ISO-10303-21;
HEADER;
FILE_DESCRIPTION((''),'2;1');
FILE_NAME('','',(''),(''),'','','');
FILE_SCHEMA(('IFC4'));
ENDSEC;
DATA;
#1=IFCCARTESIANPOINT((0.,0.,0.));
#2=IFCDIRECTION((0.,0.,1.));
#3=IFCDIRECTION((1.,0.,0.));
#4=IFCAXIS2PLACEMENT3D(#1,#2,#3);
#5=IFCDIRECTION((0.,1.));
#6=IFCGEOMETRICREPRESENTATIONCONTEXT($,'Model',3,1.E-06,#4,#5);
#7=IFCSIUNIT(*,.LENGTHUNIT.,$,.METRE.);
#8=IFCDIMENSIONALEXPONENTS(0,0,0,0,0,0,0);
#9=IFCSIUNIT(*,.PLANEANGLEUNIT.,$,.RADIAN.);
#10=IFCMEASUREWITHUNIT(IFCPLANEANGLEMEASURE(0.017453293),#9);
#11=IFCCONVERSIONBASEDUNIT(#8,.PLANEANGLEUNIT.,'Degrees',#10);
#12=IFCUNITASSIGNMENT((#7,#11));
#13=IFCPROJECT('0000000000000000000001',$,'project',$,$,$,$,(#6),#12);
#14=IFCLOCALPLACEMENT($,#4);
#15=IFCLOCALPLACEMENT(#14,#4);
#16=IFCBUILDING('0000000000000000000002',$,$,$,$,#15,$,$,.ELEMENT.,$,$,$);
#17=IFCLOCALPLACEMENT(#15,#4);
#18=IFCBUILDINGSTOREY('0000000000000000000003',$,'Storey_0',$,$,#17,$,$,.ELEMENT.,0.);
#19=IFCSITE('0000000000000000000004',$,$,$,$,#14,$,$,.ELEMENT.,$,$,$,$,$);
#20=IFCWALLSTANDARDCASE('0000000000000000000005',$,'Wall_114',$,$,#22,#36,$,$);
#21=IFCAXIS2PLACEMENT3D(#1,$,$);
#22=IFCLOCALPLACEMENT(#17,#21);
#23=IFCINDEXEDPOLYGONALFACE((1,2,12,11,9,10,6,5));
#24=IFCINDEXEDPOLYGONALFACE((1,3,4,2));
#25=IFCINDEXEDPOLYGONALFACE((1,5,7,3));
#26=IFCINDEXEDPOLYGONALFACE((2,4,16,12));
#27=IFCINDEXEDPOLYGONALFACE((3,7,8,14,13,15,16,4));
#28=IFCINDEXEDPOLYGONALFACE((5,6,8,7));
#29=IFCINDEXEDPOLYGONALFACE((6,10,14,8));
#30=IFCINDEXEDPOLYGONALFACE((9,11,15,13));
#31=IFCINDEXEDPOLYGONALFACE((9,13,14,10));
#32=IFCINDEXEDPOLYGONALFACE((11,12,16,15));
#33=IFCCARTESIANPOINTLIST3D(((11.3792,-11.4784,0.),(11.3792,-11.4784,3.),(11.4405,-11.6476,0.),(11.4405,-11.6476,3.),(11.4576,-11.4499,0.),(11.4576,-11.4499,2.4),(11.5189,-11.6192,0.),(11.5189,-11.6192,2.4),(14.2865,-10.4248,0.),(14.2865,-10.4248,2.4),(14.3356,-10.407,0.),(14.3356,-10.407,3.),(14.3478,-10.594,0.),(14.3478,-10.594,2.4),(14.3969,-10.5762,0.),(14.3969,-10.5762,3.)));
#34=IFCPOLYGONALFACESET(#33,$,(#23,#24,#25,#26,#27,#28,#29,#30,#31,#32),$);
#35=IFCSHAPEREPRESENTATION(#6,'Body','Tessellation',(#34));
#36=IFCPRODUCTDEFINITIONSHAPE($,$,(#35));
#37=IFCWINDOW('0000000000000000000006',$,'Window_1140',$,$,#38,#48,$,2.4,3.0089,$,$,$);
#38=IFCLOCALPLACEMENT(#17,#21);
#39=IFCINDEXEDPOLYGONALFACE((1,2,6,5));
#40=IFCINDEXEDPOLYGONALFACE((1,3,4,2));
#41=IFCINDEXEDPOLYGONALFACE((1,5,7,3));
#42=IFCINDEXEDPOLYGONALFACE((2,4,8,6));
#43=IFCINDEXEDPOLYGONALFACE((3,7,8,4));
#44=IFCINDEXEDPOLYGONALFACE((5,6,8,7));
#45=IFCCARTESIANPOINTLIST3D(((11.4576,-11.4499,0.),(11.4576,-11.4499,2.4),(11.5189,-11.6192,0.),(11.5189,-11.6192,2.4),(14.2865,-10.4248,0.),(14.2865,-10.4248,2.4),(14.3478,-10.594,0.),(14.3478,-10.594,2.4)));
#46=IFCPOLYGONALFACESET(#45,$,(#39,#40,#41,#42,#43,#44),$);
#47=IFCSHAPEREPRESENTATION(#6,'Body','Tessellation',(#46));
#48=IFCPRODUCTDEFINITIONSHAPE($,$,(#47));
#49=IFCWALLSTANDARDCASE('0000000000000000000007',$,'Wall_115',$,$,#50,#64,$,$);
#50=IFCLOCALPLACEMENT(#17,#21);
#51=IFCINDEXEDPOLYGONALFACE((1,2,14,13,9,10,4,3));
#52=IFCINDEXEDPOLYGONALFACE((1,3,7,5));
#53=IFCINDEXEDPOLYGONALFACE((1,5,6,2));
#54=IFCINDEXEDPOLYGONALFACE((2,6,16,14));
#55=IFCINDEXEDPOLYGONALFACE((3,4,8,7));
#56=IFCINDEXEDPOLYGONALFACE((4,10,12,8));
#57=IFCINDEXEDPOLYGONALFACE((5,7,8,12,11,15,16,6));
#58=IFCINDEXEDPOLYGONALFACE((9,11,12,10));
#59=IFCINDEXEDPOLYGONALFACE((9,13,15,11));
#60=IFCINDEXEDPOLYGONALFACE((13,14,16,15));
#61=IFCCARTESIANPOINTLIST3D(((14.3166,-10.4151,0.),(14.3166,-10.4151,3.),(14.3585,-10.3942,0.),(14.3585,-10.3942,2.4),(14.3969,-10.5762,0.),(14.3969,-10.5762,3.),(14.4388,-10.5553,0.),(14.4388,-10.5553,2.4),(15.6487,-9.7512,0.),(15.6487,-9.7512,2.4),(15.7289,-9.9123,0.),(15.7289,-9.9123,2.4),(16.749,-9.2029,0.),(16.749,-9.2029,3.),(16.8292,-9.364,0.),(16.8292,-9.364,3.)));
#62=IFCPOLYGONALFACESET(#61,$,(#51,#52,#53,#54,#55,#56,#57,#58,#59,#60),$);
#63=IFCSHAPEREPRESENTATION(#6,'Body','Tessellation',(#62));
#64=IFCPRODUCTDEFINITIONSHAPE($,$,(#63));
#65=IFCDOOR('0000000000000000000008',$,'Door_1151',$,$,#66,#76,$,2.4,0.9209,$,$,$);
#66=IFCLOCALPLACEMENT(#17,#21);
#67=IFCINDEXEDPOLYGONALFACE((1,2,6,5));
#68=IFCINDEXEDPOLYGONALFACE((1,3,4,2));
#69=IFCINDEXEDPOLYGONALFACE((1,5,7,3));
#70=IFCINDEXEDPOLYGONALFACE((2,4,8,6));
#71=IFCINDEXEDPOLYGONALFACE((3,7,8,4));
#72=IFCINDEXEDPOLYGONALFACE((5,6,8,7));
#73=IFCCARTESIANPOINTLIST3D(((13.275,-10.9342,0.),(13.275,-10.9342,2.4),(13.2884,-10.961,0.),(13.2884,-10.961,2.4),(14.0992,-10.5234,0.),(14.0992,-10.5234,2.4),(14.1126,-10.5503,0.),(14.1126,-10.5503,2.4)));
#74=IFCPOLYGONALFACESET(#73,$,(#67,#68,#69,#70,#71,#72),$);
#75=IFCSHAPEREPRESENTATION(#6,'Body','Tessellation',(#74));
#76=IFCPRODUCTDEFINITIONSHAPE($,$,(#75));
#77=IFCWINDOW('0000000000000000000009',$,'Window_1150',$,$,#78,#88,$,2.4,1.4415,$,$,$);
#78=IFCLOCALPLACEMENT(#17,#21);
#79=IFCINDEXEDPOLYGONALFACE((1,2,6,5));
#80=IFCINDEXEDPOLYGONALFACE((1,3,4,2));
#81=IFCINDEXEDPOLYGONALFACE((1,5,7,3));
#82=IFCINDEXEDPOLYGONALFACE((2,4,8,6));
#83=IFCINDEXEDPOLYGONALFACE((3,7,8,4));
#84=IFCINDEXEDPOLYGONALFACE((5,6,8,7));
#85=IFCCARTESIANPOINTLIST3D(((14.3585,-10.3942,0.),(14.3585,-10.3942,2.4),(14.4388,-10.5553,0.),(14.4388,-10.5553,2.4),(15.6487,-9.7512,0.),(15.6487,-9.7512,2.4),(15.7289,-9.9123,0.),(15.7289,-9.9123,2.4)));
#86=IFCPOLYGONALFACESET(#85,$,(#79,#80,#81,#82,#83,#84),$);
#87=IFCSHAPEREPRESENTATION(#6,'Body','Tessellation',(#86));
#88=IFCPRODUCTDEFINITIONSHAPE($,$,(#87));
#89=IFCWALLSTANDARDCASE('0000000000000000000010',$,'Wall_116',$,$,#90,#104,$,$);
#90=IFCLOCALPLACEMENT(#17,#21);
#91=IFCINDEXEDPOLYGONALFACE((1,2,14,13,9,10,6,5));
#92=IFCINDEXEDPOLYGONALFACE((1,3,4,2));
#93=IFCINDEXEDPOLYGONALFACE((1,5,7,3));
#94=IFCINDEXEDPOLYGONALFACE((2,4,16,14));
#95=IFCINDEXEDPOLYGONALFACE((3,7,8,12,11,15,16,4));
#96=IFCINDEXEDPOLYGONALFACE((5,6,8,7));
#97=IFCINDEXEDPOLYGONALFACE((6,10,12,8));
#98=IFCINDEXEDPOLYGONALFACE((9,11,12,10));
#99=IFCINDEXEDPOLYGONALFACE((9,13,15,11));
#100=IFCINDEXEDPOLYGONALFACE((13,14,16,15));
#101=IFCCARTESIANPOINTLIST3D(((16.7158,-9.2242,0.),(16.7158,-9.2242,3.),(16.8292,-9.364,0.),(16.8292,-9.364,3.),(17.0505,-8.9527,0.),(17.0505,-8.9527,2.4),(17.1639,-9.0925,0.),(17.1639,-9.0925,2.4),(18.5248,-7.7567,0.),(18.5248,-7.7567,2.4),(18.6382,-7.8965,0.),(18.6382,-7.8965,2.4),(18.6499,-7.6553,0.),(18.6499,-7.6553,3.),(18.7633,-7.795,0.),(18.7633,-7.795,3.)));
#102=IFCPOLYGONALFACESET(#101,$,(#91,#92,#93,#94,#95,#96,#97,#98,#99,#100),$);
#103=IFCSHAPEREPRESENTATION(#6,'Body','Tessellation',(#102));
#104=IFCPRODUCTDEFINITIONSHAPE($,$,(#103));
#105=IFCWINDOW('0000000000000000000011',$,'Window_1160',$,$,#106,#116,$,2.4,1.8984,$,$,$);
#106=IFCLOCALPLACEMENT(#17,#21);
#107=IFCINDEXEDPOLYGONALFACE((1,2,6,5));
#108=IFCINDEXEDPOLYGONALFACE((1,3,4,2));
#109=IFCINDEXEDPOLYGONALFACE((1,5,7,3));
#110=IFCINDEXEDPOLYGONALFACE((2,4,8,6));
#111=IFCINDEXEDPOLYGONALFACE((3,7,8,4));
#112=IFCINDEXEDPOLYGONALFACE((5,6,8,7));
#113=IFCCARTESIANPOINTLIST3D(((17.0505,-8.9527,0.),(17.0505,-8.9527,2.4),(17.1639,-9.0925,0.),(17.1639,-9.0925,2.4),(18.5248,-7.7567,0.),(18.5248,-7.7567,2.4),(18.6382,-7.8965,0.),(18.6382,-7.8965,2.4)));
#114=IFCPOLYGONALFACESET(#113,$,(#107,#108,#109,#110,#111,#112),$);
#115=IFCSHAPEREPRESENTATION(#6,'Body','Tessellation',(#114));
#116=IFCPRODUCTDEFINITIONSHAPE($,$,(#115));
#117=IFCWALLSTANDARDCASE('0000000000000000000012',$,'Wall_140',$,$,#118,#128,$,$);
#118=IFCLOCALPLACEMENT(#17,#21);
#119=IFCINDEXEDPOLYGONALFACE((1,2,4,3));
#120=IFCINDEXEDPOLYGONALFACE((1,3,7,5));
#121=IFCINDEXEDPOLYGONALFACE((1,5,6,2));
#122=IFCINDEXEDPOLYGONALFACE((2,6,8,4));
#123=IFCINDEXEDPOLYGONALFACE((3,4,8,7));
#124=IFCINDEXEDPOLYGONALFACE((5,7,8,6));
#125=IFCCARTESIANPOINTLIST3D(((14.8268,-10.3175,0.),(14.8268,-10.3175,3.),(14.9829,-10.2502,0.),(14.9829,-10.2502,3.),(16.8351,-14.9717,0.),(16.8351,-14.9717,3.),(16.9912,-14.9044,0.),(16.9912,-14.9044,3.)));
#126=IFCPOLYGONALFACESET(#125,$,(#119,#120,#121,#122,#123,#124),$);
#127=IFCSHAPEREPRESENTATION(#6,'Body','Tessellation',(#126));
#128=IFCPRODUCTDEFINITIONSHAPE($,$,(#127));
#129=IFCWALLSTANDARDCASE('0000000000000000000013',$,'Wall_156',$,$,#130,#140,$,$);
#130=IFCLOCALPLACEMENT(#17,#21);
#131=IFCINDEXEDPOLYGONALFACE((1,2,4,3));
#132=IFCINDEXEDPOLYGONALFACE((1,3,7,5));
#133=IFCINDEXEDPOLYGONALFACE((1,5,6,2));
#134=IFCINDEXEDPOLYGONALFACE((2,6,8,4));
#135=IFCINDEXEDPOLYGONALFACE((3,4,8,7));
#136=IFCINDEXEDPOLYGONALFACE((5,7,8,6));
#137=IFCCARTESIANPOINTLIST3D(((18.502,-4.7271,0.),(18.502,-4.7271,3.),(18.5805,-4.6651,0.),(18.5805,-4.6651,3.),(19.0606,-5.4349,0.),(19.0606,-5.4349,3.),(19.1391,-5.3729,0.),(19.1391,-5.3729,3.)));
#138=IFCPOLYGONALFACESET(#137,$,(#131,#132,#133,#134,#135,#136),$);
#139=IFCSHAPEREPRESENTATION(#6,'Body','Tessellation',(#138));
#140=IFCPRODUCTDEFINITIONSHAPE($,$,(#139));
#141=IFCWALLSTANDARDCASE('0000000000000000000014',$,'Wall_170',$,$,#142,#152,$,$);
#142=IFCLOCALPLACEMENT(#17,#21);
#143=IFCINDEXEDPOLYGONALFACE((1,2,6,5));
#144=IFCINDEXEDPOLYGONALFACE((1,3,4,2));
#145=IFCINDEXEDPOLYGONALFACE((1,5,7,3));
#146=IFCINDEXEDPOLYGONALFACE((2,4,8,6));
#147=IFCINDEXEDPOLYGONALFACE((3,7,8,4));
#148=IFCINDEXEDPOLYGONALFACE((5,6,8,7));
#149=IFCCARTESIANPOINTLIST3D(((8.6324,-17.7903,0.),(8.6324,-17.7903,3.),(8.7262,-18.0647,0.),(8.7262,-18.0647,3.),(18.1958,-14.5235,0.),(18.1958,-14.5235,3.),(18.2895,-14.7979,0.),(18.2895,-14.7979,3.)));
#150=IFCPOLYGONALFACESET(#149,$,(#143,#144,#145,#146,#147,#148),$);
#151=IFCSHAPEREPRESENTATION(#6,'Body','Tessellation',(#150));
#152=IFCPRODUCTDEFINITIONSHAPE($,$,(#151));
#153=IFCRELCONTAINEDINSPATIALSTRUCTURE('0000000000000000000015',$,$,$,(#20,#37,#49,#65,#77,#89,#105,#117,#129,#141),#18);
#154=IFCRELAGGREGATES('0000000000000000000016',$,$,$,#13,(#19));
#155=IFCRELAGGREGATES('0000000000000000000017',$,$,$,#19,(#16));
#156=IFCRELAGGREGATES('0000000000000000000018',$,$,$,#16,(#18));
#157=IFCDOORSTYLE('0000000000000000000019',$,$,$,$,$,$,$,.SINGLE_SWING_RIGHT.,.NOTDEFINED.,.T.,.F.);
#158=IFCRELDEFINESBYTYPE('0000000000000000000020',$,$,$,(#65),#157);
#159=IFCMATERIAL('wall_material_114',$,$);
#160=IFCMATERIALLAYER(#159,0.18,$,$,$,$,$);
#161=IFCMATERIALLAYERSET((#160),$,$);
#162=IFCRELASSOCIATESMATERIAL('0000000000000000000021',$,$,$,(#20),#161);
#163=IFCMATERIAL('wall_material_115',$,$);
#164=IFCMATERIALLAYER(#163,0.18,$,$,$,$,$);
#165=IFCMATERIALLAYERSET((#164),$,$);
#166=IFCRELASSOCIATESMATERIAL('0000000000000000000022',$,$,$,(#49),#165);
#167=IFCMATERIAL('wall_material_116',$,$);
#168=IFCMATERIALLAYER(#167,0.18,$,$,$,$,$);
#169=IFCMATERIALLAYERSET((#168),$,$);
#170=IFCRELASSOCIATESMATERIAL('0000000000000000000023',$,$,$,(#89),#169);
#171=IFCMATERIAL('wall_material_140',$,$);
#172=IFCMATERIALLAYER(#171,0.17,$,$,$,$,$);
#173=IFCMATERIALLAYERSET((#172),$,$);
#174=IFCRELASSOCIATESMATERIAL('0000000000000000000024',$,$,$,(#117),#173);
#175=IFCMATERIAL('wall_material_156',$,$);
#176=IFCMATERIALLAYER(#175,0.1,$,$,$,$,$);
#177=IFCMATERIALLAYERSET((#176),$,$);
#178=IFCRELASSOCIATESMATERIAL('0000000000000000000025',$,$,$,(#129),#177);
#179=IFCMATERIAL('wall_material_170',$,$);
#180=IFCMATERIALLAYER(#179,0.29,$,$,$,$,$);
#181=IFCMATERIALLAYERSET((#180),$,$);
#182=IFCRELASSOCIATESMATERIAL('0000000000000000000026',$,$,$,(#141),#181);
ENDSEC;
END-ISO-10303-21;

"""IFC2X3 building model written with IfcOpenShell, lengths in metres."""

from ifc_helpers import new_model, entity, si_unit, converted_unit, direction, frame, frame_2d, origin_with_axes, place, context, project, spatial, polyline, rectangle, outline, extrude, material, layer, layer_set, layer_usage, type_object, element, fill, save


model = new_model("IFC2X3")

# Units and contexts
model_context = context("Model", 3, precision=1e-06, world=origin_with_axes(), true_north=direction((0.0, 1.0)))
ifc_project = project(units=[si_unit("LENGTHUNIT", "METRE"), converted_unit("PLANEANGLEUNIT", "Degrees", entity("IfcPlaneAngleMeasure", 0.017453293), si_unit("PLANEANGLEUNIT", "RADIAN"), dimensions=[0, 0, 0, 0, 0, 0, 0])], contexts=[model_context])

# Site, building, storey
site_placement = place(None, origin_with_axes())
site = spatial("IfcSite", under=ifc_project, at=site_placement, CompositionType="ELEMENT")
building_placement = place(site_placement, origin_with_axes())
building = spatial("IfcBuilding", under=site, at=building_placement, CompositionType="ELEMENT")
storey_placement = place(building_placement, origin_with_axes())
storey = spatial("IfcBuildingStorey", under=building, at=storey_placement, Name="Storey_0", CompositionType="ELEMENT", Elevation=0.0)

# Wall, opening, window
ifc_material_1 = material(Name="wall_material_114")
ifc_layer_1 = layer(ifc_material_1, 0.18)
ifc_layer_set_1 = layer_set([ifc_layer_1])
ifc_layer_usage_1 = layer_usage(ifc_layer_set_1, "AXIS2", "NEGATIVE", 0.0)
wall_1_placement = place(storey_placement, frame((11.3792, -11.4784, 0.0), z_axis=(0.0, 0.0, 1.0), x_axis=(0.940164, 0.340721, 0.0)))
wall_1 = element("IfcWallStandardCase", 1, at=wall_1_placement, inside=storey, material=ifc_layer_usage_1, Name="Wall_114", context=model_context, shape_type="SweptSolid", body=[
    extrude(outline(polyline([(0.0, 0.0), (3.1445, 0.0), (3.1445, -0.18), (0.0, -0.18), (0.0, 0.0)])), origin_with_axes(), (0.0, 0.0, 1.0), 3.0),
])
opening_1_placement = place(wall_1_placement, frame((0.0834, 0.0, 0.0), z_axis=(0.0, 0.0, 1.0), x_axis=(1.0, 0.0, 0.0)))
opening_1 = element("IfcOpeningElement", 2, at=opening_1_placement, cuts=wall_1, context=model_context, shape_type="SweptSolid", body=[
    extrude(rectangle(XDim=3.0089, YDim=2.4, at=frame_2d((1.2, -1.5044), x_axis=(0.0, 1.0))), frame((0.0, 0.01, 0.0), z_axis=(0.0, -1.0, 0.0), x_axis=(0.0, 0.0, 1.0)), (0.0, 0.0, 1.0), 0.2),
])
window_1_placement = place(storey_placement, origin_with_axes())
window_1 = element("IfcWindow", 3, at=window_1_placement, inside=storey, Name="Window_1140", OverallHeight=2.4, OverallWidth=3.0089, context=model_context, shape_type="SweptSolid", body=[
    extrude(outline(polyline([(11.4576, -11.4499), (14.2865, -10.4248), (14.3478, -10.594), (11.5189, -11.6192), (11.4576, -11.4499)])), origin_with_axes(), (0.0, 0.0, 1.0), 2.4),
])
fill(opening_1, window_1)

# Wall, openings, door, window
ifc_material_2 = material(Name="wall_material_115")
ifc_layer_2 = layer(ifc_material_2, 0.18)
ifc_layer_set_2 = layer_set([ifc_layer_2])
ifc_layer_usage_2 = layer_usage(ifc_layer_set_2, "AXIS2", "NEGATIVE", 0.0)
wall_2_placement = place(storey_placement, frame((14.3166, -10.4151, 0.0), z_axis=(0.0, 0.0, 1.0), x_axis=(0.895012, 0.446041, 0.0)))
wall_2 = element("IfcWallStandardCase", 4, at=wall_2_placement, inside=storey, material=ifc_layer_usage_2, Name="Wall_115", context=model_context, shape_type="SweptSolid", body=[
    extrude(outline(polyline([(0.0, 0.0), (2.7176, 0.0), (2.7176, -0.18), (0.0, -0.18), (0.0, 0.0)])), origin_with_axes(), (0.0, 0.0, 1.0), 3.0),
])
opening_2_placement = place(wall_2_placement, frame((0.0468, 0.0, 0.0), z_axis=(0.0, 0.0, 1.0), x_axis=(1.0, 0.0, 0.0)))
opening_2 = element("IfcOpeningElement", 5, at=opening_2_placement, cuts=wall_2, context=model_context, shape_type="SweptSolid", body=[
    extrude(rectangle(XDim=1.4415, YDim=2.4, at=frame_2d((1.2, -0.7208), x_axis=(0.0, 1.0))), frame((0.0, 0.01, 0.0), z_axis=(0.0, -1.0, 0.0), x_axis=(0.0, 0.0, 1.0)), (0.0, 0.0, 1.0), 0.2),
])
opening_3_placement = place(wall_2_placement, frame((-1.1638, 0.0, 0.0), z_axis=(0.0, 0.0, 1.0), x_axis=(1.0, 0.0, 0.0)))
opening_3 = element("IfcOpeningElement", 6, at=opening_3_placement, cuts=wall_2, context=model_context, shape_type="SweptSolid", body=[
    extrude(rectangle(XDim=0.9209, YDim=2.4, at=frame_2d((1.2, -0.4604), x_axis=(0.0, 1.0))), frame((0.0, 0.01, 0.0), z_axis=(0.0, -1.0, 0.0), x_axis=(0.0, 0.0, 1.0)), (0.0, 0.0, 1.0), 0.2),
])
door_style_1 = type_object("IfcDoorStyle", ConstructionType="NOTDEFINED", OperationType="SINGLE_SWING_RIGHT", ParameterTakesPrecedence=True, Sizeable=False)
door_1_placement = place(storey_placement, origin_with_axes())
door_1 = element("IfcDoor", 7, at=door_1_placement, inside=storey, type_object=door_style_1, Name="Door_1151", OverallHeight=2.4, OverallWidth=0.9209, context=model_context, shape_type="SweptSolid", body=[
    extrude(outline(polyline([(13.275, -10.9342), (14.0992, -10.5234), (14.1126, -10.5503), (13.2884, -10.961), (13.275, -10.9342)])), origin_with_axes(), (0.0, 0.0, 1.0), 2.4),
])
fill(opening_3, door_1)
window_2_placement = place(storey_placement, origin_with_axes())
window_2 = element("IfcWindow", 8, at=window_2_placement, inside=storey, Name="Window_1150", OverallHeight=2.4, OverallWidth=1.4415, context=model_context, shape_type="SweptSolid", body=[
    extrude(outline(polyline([(14.3585, -10.3942), (15.6487, -9.7512), (15.7289, -9.9123), (14.4388, -10.5553), (14.3585, -10.3942)])), origin_with_axes(), (0.0, 0.0, 1.0), 2.4),
])
fill(opening_2, window_2)

# Wall, opening, window
ifc_material_3 = material(Name="wall_material_116")
ifc_layer_3 = layer(ifc_material_3, 0.18)
ifc_layer_set_3 = layer_set([ifc_layer_3])
ifc_layer_usage_3 = layer_usage(ifc_layer_set_3, "AXIS2", "NEGATIVE", 0.0)
wall_3_placement = place(storey_placement, frame((16.7158, -9.2242, 0.0), z_axis=(0.0, 0.0, 1.0), x_axis=(0.776592, 0.630003, 0.0)))
wall_3 = element("IfcWallStandardCase", 9, at=wall_3_placement, inside=storey, material=ifc_layer_usage_3, Name="Wall_116", context=model_context, shape_type="SweptSolid", body=[
    extrude(outline(polyline([(0.0, 0.0), (2.4904, 0.0), (2.4904, -0.18), (0.0, -0.18), (0.0, 0.0)])), origin_with_axes(), (0.0, 0.0, 1.0), 3.0),
])
opening_4_placement = place(wall_3_placement, frame((0.431, 0.0, 0.0), z_axis=(0.0, 0.0, 1.0), x_axis=(1.0, 0.0, 0.0)))
opening_4 = element("IfcOpeningElement", 10, at=opening_4_placement, cuts=wall_3, context=model_context, shape_type="SweptSolid", body=[
    extrude(rectangle(XDim=1.8984, YDim=2.4, at=frame_2d((1.2, -0.9492), x_axis=(0.0, 1.0))), frame((0.0, 0.01, 0.0), z_axis=(0.0, -1.0, 0.0), x_axis=(0.0, 0.0, 1.0)), (0.0, 0.0, 1.0), 0.2),
])
window_3_placement = place(storey_placement, origin_with_axes())
window_3 = element("IfcWindow", 11, at=window_3_placement, inside=storey, Name="Window_1160", OverallHeight=2.4, OverallWidth=1.8984, context=model_context, shape_type="SweptSolid", body=[
    extrude(outline(polyline([(17.0505, -8.9527), (18.5248, -7.7567), (18.6382, -7.8965), (17.1639, -9.0925), (17.0505, -8.9527)])), origin_with_axes(), (0.0, 0.0, 1.0), 2.4),
])
fill(opening_4, window_3)

# Walls
ifc_material_4 = material(Name="wall_material_140")
ifc_layer_4 = layer(ifc_material_4, 0.17)
ifc_layer_set_4 = layer_set([ifc_layer_4])
ifc_layer_usage_4 = layer_usage(ifc_layer_set_4, "AXIS2", "NEGATIVE", 0.0)
wall_4_placement = place(storey_placement, frame((14.9829, -10.2502, 0.0), z_axis=(0.0, 0.0, 1.0), x_axis=(0.396187, -0.91817, 0.0)))
element("IfcWallStandardCase", 12, at=wall_4_placement, inside=storey, material=ifc_layer_usage_4, Name="Wall_140", context=model_context, shape_type="SweptSolid", body=[
    extrude(outline(polyline([(0.0, 0.0), (5.069, 0.0), (5.069, -0.17), (0.0, -0.17), (0.0, 0.0)])), origin_with_axes(), (0.0, 0.0, 1.0), 3.0),
])
ifc_material_5 = material(Name="wall_material_156")
ifc_layer_5 = layer(ifc_material_5, 0.1)
ifc_layer_set_5 = layer_set([ifc_layer_5])
ifc_layer_usage_5 = layer_usage(ifc_layer_set_5, "AXIS2", "POSITIVE", 0.0)
wall_5_placement = place(storey_placement, frame((18.5021, -4.7271, 0.0), z_axis=(0.0, 0.0, 1.0), x_axis=(0.619505, -0.784993, 0.0)))
element("IfcWallStandardCase", 13, at=wall_5_placement, inside=storey, material=ifc_layer_usage_5, Name="Wall_156", context=model_context, shape_type="SweptSolid", body=[
    extrude(outline(polyline([(0.0, 0.1), (0.9016, 0.1), (0.9016, 0.0), (0.0, 0.0), (0.0, 0.1)])), origin_with_axes(), (0.0, 0.0, 1.0), 3.0),
])
ifc_material_6 = material(Name="wall_material_170")
ifc_layer_6 = layer(ifc_material_6, 0.29)
ifc_layer_set_6 = layer_set([ifc_layer_6])
ifc_layer_usage_6 = layer_usage(ifc_layer_set_6, "AXIS2", "NEGATIVE", 0.0)
wall_6_placement = place(storey_placement, frame((18.2895, -14.7979, 0.0), z_axis=(0.0, 0.0, 1.0), x_axis=(-0.946311, -0.323257, 0.0)))
element("IfcWallStandardCase", 14, at=wall_6_placement, inside=storey, material=ifc_layer_usage_6, Name="Wall_170", context=model_context, shape_type="SweptSolid", body=[
    extrude(outline(polyline([(0.0, 0.0), (10.1059, 0.0), (10.1059, -0.29), (0.0, -0.29), (0.0, 0.0)])), origin_with_axes(), (0.0, 0.0, 1.0), 3.0),
])

save(model, "model.ifc")
